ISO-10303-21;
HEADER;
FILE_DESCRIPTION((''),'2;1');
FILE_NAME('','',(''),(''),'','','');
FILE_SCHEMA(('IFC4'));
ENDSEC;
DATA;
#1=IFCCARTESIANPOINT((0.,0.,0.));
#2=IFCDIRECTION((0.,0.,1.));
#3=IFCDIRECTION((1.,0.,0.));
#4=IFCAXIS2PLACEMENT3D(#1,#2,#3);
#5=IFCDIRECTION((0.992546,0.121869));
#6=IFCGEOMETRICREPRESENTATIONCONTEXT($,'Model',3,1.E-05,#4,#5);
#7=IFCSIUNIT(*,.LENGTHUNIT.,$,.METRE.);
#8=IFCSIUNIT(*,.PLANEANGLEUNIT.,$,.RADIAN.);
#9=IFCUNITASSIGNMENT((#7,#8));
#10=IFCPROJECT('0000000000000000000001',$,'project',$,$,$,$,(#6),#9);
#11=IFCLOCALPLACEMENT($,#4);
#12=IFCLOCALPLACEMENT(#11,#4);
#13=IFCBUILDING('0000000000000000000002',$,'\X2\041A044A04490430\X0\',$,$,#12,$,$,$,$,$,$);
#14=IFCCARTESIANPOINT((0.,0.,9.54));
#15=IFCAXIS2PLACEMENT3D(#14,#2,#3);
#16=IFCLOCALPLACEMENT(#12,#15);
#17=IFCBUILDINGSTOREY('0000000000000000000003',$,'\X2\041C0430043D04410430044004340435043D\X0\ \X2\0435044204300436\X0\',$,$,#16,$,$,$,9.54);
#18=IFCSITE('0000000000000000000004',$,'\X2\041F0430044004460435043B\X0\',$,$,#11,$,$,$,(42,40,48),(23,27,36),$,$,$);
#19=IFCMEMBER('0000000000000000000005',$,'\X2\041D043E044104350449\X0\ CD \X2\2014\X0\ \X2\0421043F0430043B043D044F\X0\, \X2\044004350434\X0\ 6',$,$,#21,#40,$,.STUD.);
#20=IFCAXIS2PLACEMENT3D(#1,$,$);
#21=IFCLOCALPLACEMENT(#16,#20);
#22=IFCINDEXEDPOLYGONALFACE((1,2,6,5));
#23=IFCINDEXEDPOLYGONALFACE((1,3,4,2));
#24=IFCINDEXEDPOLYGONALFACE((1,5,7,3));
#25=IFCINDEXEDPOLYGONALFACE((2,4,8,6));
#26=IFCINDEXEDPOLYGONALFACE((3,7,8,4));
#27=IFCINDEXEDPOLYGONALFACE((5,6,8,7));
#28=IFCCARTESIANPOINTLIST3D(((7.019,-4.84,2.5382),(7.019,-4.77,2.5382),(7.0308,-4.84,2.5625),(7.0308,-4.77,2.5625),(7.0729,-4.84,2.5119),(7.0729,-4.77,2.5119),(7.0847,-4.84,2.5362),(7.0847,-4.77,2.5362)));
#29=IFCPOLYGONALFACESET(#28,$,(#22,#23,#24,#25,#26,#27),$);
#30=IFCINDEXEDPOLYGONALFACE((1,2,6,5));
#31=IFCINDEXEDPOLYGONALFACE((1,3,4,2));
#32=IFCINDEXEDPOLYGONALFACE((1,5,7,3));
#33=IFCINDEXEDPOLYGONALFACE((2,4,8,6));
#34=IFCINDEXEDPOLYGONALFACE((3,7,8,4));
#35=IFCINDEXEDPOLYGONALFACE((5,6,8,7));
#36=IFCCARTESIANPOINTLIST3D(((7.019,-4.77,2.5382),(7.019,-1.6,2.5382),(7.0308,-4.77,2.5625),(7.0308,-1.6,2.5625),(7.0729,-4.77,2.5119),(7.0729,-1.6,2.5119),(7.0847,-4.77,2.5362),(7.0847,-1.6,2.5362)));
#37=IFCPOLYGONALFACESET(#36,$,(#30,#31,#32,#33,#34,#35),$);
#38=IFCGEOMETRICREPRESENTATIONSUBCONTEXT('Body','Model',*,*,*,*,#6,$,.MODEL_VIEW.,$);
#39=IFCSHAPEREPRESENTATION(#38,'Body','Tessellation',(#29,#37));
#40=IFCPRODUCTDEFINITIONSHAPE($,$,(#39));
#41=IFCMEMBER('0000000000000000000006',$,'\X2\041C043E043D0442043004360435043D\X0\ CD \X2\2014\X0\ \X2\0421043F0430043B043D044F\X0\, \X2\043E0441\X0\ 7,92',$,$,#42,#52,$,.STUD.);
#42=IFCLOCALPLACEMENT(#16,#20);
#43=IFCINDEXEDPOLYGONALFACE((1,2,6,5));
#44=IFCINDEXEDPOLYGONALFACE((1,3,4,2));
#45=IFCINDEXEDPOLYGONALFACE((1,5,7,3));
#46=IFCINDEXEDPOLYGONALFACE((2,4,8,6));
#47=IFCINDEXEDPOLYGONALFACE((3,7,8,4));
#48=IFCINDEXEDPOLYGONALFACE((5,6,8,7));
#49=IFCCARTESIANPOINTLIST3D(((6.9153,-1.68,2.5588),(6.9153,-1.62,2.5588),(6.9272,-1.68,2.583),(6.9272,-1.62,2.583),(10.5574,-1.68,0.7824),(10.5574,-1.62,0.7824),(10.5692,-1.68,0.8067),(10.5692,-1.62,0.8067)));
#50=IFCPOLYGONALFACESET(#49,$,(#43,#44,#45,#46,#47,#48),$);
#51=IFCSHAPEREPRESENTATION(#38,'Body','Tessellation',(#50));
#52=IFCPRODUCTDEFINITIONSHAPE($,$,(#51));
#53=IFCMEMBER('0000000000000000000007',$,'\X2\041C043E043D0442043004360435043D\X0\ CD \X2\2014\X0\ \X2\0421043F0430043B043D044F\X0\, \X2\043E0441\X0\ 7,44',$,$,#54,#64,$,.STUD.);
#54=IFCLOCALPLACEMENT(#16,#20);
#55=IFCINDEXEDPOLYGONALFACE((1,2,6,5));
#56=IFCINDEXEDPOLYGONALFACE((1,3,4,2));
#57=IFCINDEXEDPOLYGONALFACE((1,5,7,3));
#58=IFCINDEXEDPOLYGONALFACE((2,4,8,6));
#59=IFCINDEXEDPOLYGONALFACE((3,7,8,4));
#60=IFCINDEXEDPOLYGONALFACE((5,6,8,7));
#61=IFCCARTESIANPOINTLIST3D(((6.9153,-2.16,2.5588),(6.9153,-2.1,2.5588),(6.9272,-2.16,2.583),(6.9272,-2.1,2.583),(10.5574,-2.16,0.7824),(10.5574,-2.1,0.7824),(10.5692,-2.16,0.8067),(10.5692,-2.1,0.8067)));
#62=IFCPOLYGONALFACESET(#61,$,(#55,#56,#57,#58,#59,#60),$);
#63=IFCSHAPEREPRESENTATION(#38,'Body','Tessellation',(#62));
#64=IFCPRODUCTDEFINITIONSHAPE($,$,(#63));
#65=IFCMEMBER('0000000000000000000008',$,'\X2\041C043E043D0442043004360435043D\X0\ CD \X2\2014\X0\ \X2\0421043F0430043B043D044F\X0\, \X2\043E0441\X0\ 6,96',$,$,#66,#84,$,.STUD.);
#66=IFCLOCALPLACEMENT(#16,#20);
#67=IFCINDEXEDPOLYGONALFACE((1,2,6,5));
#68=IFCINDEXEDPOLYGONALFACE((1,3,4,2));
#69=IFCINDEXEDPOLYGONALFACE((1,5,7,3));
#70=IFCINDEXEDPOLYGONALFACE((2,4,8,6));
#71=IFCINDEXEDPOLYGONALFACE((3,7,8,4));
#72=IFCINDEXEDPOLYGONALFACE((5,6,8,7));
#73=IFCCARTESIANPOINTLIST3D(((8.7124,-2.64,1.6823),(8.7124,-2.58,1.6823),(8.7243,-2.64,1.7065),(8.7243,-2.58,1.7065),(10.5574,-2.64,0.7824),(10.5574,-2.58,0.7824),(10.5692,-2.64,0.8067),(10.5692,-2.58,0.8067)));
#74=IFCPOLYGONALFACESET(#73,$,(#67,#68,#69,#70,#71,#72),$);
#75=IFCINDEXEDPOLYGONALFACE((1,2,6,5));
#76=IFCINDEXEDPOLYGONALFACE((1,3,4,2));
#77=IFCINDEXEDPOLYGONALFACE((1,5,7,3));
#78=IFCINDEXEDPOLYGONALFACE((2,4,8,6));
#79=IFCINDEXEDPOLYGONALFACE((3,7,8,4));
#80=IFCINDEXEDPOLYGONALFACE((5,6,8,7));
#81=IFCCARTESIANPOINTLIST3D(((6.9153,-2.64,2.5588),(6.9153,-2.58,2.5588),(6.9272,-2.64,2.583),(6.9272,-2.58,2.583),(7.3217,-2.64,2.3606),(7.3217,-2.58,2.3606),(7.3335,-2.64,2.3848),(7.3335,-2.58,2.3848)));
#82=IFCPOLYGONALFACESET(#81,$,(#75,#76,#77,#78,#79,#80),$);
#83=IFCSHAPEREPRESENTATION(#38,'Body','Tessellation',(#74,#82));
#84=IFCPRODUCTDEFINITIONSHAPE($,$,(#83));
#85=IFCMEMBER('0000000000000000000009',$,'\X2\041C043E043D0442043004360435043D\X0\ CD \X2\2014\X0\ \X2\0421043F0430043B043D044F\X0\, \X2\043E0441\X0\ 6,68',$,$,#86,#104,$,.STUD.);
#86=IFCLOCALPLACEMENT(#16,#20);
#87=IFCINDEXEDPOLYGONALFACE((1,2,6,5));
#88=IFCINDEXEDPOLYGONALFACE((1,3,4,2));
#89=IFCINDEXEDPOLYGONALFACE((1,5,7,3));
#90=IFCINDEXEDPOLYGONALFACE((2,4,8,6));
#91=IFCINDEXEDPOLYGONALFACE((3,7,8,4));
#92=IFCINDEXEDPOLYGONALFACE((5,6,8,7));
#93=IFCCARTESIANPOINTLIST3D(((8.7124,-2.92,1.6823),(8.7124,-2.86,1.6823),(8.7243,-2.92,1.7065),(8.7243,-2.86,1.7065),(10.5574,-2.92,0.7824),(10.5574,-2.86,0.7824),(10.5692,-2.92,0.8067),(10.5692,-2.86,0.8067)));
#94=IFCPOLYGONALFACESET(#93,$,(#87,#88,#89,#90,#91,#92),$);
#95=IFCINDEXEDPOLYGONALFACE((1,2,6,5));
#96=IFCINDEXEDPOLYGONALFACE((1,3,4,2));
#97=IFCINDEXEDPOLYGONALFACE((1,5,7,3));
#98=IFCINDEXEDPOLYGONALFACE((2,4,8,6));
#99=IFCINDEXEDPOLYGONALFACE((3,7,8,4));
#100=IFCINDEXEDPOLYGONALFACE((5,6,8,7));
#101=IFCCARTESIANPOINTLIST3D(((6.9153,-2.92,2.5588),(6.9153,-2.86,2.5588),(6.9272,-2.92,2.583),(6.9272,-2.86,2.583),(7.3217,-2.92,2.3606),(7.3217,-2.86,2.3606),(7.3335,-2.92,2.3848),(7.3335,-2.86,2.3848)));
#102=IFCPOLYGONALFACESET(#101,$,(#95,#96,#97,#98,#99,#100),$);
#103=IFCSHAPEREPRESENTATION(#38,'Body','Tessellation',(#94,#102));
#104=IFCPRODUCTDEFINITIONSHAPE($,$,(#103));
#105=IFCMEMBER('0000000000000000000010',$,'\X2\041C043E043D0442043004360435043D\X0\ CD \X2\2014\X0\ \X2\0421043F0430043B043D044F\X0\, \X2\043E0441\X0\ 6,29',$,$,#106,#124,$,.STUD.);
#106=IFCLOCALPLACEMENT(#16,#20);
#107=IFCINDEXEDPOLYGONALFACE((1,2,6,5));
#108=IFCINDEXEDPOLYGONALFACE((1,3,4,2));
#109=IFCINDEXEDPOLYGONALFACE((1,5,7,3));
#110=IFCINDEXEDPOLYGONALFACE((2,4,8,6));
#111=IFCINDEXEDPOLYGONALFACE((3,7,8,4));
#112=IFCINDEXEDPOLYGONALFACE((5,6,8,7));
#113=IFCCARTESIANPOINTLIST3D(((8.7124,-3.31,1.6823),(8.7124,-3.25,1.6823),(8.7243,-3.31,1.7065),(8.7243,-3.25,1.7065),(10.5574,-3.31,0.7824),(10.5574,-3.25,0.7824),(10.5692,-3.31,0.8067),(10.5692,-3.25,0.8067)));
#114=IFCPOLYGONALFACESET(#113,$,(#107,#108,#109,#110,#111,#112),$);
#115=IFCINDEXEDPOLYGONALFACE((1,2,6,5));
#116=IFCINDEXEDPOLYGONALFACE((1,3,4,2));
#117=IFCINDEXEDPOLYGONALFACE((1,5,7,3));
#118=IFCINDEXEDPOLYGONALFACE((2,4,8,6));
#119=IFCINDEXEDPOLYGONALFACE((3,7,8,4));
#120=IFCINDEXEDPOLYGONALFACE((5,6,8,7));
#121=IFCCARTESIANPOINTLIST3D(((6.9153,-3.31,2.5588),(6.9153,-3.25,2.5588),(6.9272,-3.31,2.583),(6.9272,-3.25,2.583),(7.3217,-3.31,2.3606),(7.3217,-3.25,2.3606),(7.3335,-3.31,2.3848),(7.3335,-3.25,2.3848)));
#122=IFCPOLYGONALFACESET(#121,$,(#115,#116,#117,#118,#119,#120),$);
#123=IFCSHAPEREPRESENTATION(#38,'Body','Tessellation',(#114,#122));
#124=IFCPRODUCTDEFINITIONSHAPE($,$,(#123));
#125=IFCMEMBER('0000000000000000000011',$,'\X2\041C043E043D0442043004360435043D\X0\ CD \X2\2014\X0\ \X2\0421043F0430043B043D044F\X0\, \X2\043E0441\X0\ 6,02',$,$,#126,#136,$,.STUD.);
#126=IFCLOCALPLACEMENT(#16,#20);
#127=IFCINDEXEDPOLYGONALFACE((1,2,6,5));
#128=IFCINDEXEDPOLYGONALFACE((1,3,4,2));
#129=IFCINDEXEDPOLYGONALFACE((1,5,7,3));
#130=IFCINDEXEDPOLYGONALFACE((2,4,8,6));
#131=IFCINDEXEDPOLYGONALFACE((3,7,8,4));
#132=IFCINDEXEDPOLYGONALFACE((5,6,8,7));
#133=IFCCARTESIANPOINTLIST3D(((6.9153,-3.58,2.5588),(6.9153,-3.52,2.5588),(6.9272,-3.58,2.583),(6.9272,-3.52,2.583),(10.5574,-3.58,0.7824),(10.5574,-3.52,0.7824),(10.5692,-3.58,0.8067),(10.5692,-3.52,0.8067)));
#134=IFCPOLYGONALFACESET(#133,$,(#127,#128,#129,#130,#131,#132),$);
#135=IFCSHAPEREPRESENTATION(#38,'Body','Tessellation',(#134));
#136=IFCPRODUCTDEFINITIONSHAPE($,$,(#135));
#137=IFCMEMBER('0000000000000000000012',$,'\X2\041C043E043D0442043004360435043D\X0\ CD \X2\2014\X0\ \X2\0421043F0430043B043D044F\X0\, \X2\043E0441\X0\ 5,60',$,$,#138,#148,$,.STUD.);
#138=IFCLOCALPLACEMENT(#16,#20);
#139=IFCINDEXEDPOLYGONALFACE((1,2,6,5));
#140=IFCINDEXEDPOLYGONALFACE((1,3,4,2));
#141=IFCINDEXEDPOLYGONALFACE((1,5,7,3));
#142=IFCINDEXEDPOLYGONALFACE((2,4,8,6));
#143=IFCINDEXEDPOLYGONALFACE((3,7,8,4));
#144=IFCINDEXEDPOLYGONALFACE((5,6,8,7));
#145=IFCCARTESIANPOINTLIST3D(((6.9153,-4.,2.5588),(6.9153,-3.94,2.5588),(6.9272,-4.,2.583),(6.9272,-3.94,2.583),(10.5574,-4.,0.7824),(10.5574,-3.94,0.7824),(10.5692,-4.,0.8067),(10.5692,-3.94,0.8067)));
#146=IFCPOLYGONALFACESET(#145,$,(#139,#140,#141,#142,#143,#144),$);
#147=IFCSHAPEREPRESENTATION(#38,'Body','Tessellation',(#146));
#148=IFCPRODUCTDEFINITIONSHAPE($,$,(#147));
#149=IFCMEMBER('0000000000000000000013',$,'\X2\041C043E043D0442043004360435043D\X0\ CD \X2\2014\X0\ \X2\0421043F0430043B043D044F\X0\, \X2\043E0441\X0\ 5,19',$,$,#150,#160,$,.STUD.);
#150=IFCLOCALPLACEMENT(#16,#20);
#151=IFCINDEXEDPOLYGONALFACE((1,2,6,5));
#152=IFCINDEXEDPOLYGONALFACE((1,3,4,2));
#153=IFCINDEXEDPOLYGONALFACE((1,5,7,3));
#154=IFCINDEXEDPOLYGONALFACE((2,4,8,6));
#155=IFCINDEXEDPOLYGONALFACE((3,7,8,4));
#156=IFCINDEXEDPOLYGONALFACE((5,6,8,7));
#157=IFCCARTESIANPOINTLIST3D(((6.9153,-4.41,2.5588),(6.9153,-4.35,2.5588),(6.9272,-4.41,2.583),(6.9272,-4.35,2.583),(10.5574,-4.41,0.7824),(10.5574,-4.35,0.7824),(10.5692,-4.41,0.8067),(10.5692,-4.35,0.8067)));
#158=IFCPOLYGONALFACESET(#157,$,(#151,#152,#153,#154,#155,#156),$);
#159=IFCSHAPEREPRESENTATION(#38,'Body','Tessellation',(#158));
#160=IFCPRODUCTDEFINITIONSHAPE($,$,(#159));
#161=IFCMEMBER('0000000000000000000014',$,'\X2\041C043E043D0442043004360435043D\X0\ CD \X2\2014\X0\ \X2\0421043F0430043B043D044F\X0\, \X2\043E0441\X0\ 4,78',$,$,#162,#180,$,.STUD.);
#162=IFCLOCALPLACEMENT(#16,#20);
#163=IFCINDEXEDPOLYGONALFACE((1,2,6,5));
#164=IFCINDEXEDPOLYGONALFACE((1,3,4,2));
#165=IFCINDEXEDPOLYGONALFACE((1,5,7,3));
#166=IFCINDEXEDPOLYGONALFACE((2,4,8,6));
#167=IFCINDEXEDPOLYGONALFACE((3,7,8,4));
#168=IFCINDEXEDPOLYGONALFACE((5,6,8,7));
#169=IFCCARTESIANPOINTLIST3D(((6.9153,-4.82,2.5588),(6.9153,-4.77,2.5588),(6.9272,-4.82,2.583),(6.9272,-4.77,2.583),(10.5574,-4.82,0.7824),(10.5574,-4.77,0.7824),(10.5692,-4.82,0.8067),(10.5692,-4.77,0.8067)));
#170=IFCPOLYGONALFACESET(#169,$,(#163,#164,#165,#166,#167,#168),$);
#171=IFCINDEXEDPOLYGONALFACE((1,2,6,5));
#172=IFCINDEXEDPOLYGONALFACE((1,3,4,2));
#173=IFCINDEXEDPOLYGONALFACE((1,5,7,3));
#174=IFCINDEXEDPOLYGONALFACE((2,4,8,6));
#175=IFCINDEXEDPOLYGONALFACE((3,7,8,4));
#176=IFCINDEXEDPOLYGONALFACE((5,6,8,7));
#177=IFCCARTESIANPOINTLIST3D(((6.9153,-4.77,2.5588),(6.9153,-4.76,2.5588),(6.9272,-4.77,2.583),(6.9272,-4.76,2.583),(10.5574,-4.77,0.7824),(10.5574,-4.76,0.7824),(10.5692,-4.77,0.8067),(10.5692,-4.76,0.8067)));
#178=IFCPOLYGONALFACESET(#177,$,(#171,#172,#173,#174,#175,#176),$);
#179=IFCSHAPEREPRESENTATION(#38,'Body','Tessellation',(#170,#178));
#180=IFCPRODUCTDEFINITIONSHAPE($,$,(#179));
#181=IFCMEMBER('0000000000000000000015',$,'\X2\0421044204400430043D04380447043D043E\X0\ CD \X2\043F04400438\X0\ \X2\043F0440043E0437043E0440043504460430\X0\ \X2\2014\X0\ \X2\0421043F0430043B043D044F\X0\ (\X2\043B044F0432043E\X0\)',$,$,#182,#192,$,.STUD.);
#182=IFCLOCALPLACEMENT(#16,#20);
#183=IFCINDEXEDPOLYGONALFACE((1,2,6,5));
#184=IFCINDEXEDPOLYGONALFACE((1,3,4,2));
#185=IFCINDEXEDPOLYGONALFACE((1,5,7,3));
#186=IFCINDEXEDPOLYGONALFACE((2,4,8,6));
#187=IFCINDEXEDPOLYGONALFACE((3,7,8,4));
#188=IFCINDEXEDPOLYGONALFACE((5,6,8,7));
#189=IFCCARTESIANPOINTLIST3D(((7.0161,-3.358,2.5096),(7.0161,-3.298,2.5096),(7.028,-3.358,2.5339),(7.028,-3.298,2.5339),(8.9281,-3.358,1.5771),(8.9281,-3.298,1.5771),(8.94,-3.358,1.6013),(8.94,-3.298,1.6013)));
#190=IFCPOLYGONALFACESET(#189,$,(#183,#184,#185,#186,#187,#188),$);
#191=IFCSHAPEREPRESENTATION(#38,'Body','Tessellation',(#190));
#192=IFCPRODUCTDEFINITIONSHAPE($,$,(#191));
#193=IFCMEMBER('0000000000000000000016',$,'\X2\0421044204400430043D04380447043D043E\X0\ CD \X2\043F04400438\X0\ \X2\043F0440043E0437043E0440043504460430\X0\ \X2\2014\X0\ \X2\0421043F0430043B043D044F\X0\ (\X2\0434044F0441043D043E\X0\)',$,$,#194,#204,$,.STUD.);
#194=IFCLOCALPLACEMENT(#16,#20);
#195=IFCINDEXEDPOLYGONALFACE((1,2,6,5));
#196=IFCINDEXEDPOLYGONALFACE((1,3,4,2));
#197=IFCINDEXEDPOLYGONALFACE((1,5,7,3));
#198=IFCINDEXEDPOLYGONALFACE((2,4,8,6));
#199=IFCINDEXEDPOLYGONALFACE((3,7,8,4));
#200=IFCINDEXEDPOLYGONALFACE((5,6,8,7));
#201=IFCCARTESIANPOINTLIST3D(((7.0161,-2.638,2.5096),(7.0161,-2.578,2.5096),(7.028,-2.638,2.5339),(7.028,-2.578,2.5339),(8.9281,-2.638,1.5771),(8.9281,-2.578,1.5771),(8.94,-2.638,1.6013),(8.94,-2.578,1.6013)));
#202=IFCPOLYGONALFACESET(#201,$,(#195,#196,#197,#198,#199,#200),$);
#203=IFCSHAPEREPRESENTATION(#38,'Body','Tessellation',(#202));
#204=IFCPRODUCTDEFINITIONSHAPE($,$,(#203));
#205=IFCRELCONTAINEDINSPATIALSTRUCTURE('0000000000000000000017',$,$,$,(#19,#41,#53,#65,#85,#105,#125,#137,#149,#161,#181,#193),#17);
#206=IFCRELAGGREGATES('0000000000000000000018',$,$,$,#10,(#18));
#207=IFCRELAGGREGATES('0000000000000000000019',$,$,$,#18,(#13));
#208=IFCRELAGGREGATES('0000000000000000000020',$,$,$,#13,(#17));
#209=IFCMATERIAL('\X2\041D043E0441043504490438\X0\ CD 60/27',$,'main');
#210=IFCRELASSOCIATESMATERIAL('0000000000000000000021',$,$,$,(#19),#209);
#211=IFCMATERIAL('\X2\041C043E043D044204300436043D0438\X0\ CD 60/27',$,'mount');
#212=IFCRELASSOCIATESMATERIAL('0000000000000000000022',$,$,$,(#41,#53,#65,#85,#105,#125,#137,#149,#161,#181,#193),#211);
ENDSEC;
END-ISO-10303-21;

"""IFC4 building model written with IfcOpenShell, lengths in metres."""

from ifc_helpers import new_model, si_unit, direction, frame, origin_with_axes, place, context, subcontext, project, spatial, polyline, outline, extrude, material, element, save


model = new_model("IFC4")

# Units and contexts
model_context = context("Model", 3, precision=1e-05, world=origin_with_axes(), true_north=direction((0.992546, 0.121869)))
body_context = subcontext(model_context, "Body", "Model", "MODEL_VIEW")
ifc_project = project(units=[si_unit("LENGTHUNIT", "METRE"), si_unit("PLANEANGLEUNIT", "RADIAN")], contexts=[model_context])

# Site, building, storey
site_placement = place(None, origin_with_axes())
site = spatial("IfcSite", under=ifc_project, at=site_placement, Name="Парцел", RefLatitude=(42, 40, 48), RefLongitude=(23, 27, 36))
building_placement = place(site_placement, origin_with_axes())
building = spatial("IfcBuilding", under=site, at=building_placement, Name="Къща")
storey_placement = place(building_placement, frame((0.0, 0.0, 9.54), z_axis=(0.0, 0.0, 1.0), x_axis=(1.0, 0.0, 0.0)))
storey = spatial("IfcBuildingStorey", under=building, at=storey_placement, Name="Мансарден етаж", Elevation=9.54)

# Members
ifc_material_1 = material(Name="Монтажни CD 60/27", Category="mount")
ifc_material_2 = material(Name="Носещи CD 60/27", Category="main")
member_1_placement = place(storey_placement, origin_with_axes())
element("IfcMember", 1, at=member_1_placement, inside=storey, material=ifc_material_2, Name="Носещ CD — Спалня, ред 6", PredefinedType="STUD", context=body_context, shape_type="SweptSolid", body=[
    extrude(outline(polyline([(7.0729, -2.5119), (7.019, -2.5383), (7.0308, -2.5625), (7.0847, -2.5362), (7.0729, -2.5119)])), frame((0.0, -4.84, 0.0), z_axis=(0.0, 1.0, 0.0), x_axis=(1.0, 0.0, 0.0)), (0.0, 0.0, 1.0), 0.07),
    extrude(outline(polyline([(7.0729, -2.5119), (7.019, -2.5383), (7.0308, -2.5625), (7.0847, -2.5362), (7.0729, -2.5119)])), frame((0.0, -4.77, 0.0), z_axis=(0.0, 1.0, 0.0), x_axis=(1.0, 0.0, 0.0)), (0.0, 0.0, 1.0), 3.17),
])
member_2_placement = place(storey_placement, origin_with_axes())
element("IfcMember", 2, at=member_2_placement, inside=storey, material=ifc_material_1, Name="Монтажен CD — Спалня, ос 7,92", PredefinedType="STUD", context=body_context, shape_type="SweptSolid", body=[
    extrude(outline(polyline([(10.5574, -0.7824), (6.9153, -2.5587), (6.9272, -2.583), (10.5692, -0.8067), (10.5574, -0.7824)])), frame((0.0, -1.68, 0.0), z_axis=(0.0, 1.0, 0.0), x_axis=(1.0, 0.0, 0.0)), (0.0, 0.0, 1.0), 0.06),
])
member_3_placement = place(storey_placement, origin_with_axes())
element("IfcMember", 3, at=member_3_placement, inside=storey, material=ifc_material_1, Name="Монтажен CD — Спалня, ос 7,44", PredefinedType="STUD", context=body_context, shape_type="SweptSolid", body=[
    extrude(outline(polyline([(10.5574, -0.7824), (6.9153, -2.5587), (6.9272, -2.583), (10.5692, -0.8067), (10.5574, -0.7824)])), frame((0.0, -2.16, 0.0), z_axis=(0.0, 1.0, 0.0), x_axis=(1.0, 0.0, 0.0)), (0.0, 0.0, 1.0), 0.06),
])
member_4_placement = place(storey_placement, origin_with_axes())
element("IfcMember", 4, at=member_4_placement, inside=storey, material=ifc_material_1, Name="Монтажен CD — Спалня, ос 6,96", PredefinedType="STUD", context=body_context, shape_type="SweptSolid", body=[
    extrude(outline(polyline([(10.5574, -0.7824), (8.7124, -1.6823), (8.7243, -1.7065), (10.5692, -0.8067), (10.5574, -0.7824)])), frame((0.0, -2.64, 0.0), z_axis=(0.0, 1.0, 0.0), x_axis=(1.0, 0.0, 0.0)), (0.0, 0.0, 1.0), 0.06),
    extrude(outline(polyline([(7.3217, -2.3606), (6.9153, -2.5587), (6.9272, -2.583), (7.3335, -2.3848), (7.3217, -2.3606)])), frame((0.0, -2.64, 0.0), z_axis=(0.0, 1.0, 0.0), x_axis=(1.0, 0.0, 0.0)), (0.0, 0.0, 1.0), 0.06),
])
member_5_placement = place(storey_placement, origin_with_axes())
element("IfcMember", 5, at=member_5_placement, inside=storey, material=ifc_material_1, Name="Монтажен CD — Спалня, ос 6,68", PredefinedType="STUD", context=body_context, shape_type="SweptSolid", body=[
    extrude(outline(polyline([(10.5574, -0.7824), (8.7124, -1.6823), (8.7243, -1.7065), (10.5692, -0.8067), (10.5574, -0.7824)])), frame((0.0, -2.92, 0.0), z_axis=(0.0, 1.0, 0.0), x_axis=(1.0, 0.0, 0.0)), (0.0, 0.0, 1.0), 0.06),
    extrude(outline(polyline([(7.3217, -2.3606), (6.9153, -2.5587), (6.9272, -2.583), (7.3335, -2.3848), (7.3217, -2.3606)])), frame((0.0, -2.92, 0.0), z_axis=(0.0, 1.0, 0.0), x_axis=(1.0, 0.0, 0.0)), (0.0, 0.0, 1.0), 0.06),
])
member_6_placement = place(storey_placement, origin_with_axes())
element("IfcMember", 6, at=member_6_placement, inside=storey, material=ifc_material_1, Name="Монтажен CD — Спалня, ос 6,29", PredefinedType="STUD", context=body_context, shape_type="SweptSolid", body=[
    extrude(outline(polyline([(10.5574, -0.7824), (8.7124, -1.6823), (8.7243, -1.7065), (10.5692, -0.8067), (10.5574, -0.7824)])), frame((0.0, -3.31, 0.0), z_axis=(0.0, 1.0, 0.0), x_axis=(1.0, 0.0, 0.0)), (0.0, 0.0, 1.0), 0.06),
    extrude(outline(polyline([(7.3217, -2.3606), (6.9153, -2.5587), (6.9272, -2.583), (7.3335, -2.3848), (7.3217, -2.3606)])), frame((0.0, -3.31, 0.0), z_axis=(0.0, 1.0, 0.0), x_axis=(1.0, 0.0, 0.0)), (0.0, 0.0, 1.0), 0.06),
])
member_7_placement = place(storey_placement, origin_with_axes())
element("IfcMember", 7, at=member_7_placement, inside=storey, material=ifc_material_1, Name="Монтажен CD — Спалня, ос 6,02", PredefinedType="STUD", context=body_context, shape_type="SweptSolid", body=[
    extrude(outline(polyline([(10.5574, -0.7824), (6.9153, -2.5587), (6.9272, -2.583), (10.5692, -0.8067), (10.5574, -0.7824)])), frame((0.0, -3.58, 0.0), z_axis=(0.0, 1.0, 0.0), x_axis=(1.0, 0.0, 0.0)), (0.0, 0.0, 1.0), 0.06),
])
member_8_placement = place(storey_placement, origin_with_axes())
element("IfcMember", 8, at=member_8_placement, inside=storey, material=ifc_material_1, Name="Монтажен CD — Спалня, ос 5,60", PredefinedType="STUD", context=body_context, shape_type="SweptSolid", body=[
    extrude(outline(polyline([(10.5574, -0.7824), (6.9153, -2.5587), (6.9272, -2.583), (10.5692, -0.8067), (10.5574, -0.7824)])), frame((0.0, -4.0, 0.0), z_axis=(0.0, 1.0, 0.0), x_axis=(1.0, 0.0, 0.0)), (0.0, 0.0, 1.0), 0.06),
])
member_9_placement = place(storey_placement, origin_with_axes())
element("IfcMember", 9, at=member_9_placement, inside=storey, material=ifc_material_1, Name="Монтажен CD — Спалня, ос 5,19", PredefinedType="STUD", context=body_context, shape_type="SweptSolid", body=[
    extrude(outline(polyline([(10.5574, -0.7824), (6.9153, -2.5587), (6.9272, -2.583), (10.5692, -0.8067), (10.5574, -0.7824)])), frame((0.0, -4.41, 0.0), z_axis=(0.0, 1.0, 0.0), x_axis=(1.0, 0.0, 0.0)), (0.0, 0.0, 1.0), 0.06),
])
member_10_placement = place(storey_placement, origin_with_axes())
element("IfcMember", 10, at=member_10_placement, inside=storey, material=ifc_material_1, Name="Монтажен CD — Спалня, ос 4,78", PredefinedType="STUD", context=body_context, shape_type="SweptSolid", body=[
    extrude(outline(polyline([(10.5574, -0.7824), (6.9153, -2.5587), (6.9272, -2.583), (10.5692, -0.8067), (10.5574, -0.7824)])), frame((0.0, -4.82, 0.0), z_axis=(0.0, 1.0, 0.0), x_axis=(1.0, 0.0, 0.0)), (0.0, 0.0, 1.0), 0.05),
    extrude(outline(polyline([(10.5574, -0.7824), (6.9153, -2.5587), (6.9272, -2.583), (10.5692, -0.8067), (10.5574, -0.7824)])), frame((0.0, -4.77, 0.0), z_axis=(0.0, 1.0, 0.0), x_axis=(1.0, 0.0, 0.0)), (0.0, 0.0, 1.0), 0.01),
])
member_11_placement = place(storey_placement, origin_with_axes())
element("IfcMember", 11, at=member_11_placement, inside=storey, material=ifc_material_1, Name="Странично CD при прозореца — Спалня (ляво)", PredefinedType="STUD", context=body_context, shape_type="SweptSolid", body=[
    extrude(outline(polyline([(8.9281, -1.5771), (7.0161, -2.5096), (7.028, -2.5339), (8.94, -1.6013), (8.9281, -1.5771)])), frame((0.0, -3.358, 0.0), z_axis=(0.0, 1.0, 0.0), x_axis=(1.0, 0.0, 0.0)), (0.0, 0.0, 1.0), 0.06),
])
member_12_placement = place(storey_placement, origin_with_axes())
element("IfcMember", 12, at=member_12_placement, inside=storey, material=ifc_material_1, Name="Странично CD при прозореца — Спалня (дясно)", PredefinedType="STUD", context=body_context, shape_type="SweptSolid", body=[
    extrude(outline(polyline([(8.9281, -1.5771), (7.0161, -2.5096), (7.028, -2.5339), (8.94, -1.6013), (8.9281, -1.5771)])), frame((0.0, -2.638, 0.0), z_axis=(0.0, 1.0, 0.0), x_axis=(1.0, 0.0, 0.0)), (0.0, 0.0, 1.0), 0.06),
])

save(model, "model.ifc")
